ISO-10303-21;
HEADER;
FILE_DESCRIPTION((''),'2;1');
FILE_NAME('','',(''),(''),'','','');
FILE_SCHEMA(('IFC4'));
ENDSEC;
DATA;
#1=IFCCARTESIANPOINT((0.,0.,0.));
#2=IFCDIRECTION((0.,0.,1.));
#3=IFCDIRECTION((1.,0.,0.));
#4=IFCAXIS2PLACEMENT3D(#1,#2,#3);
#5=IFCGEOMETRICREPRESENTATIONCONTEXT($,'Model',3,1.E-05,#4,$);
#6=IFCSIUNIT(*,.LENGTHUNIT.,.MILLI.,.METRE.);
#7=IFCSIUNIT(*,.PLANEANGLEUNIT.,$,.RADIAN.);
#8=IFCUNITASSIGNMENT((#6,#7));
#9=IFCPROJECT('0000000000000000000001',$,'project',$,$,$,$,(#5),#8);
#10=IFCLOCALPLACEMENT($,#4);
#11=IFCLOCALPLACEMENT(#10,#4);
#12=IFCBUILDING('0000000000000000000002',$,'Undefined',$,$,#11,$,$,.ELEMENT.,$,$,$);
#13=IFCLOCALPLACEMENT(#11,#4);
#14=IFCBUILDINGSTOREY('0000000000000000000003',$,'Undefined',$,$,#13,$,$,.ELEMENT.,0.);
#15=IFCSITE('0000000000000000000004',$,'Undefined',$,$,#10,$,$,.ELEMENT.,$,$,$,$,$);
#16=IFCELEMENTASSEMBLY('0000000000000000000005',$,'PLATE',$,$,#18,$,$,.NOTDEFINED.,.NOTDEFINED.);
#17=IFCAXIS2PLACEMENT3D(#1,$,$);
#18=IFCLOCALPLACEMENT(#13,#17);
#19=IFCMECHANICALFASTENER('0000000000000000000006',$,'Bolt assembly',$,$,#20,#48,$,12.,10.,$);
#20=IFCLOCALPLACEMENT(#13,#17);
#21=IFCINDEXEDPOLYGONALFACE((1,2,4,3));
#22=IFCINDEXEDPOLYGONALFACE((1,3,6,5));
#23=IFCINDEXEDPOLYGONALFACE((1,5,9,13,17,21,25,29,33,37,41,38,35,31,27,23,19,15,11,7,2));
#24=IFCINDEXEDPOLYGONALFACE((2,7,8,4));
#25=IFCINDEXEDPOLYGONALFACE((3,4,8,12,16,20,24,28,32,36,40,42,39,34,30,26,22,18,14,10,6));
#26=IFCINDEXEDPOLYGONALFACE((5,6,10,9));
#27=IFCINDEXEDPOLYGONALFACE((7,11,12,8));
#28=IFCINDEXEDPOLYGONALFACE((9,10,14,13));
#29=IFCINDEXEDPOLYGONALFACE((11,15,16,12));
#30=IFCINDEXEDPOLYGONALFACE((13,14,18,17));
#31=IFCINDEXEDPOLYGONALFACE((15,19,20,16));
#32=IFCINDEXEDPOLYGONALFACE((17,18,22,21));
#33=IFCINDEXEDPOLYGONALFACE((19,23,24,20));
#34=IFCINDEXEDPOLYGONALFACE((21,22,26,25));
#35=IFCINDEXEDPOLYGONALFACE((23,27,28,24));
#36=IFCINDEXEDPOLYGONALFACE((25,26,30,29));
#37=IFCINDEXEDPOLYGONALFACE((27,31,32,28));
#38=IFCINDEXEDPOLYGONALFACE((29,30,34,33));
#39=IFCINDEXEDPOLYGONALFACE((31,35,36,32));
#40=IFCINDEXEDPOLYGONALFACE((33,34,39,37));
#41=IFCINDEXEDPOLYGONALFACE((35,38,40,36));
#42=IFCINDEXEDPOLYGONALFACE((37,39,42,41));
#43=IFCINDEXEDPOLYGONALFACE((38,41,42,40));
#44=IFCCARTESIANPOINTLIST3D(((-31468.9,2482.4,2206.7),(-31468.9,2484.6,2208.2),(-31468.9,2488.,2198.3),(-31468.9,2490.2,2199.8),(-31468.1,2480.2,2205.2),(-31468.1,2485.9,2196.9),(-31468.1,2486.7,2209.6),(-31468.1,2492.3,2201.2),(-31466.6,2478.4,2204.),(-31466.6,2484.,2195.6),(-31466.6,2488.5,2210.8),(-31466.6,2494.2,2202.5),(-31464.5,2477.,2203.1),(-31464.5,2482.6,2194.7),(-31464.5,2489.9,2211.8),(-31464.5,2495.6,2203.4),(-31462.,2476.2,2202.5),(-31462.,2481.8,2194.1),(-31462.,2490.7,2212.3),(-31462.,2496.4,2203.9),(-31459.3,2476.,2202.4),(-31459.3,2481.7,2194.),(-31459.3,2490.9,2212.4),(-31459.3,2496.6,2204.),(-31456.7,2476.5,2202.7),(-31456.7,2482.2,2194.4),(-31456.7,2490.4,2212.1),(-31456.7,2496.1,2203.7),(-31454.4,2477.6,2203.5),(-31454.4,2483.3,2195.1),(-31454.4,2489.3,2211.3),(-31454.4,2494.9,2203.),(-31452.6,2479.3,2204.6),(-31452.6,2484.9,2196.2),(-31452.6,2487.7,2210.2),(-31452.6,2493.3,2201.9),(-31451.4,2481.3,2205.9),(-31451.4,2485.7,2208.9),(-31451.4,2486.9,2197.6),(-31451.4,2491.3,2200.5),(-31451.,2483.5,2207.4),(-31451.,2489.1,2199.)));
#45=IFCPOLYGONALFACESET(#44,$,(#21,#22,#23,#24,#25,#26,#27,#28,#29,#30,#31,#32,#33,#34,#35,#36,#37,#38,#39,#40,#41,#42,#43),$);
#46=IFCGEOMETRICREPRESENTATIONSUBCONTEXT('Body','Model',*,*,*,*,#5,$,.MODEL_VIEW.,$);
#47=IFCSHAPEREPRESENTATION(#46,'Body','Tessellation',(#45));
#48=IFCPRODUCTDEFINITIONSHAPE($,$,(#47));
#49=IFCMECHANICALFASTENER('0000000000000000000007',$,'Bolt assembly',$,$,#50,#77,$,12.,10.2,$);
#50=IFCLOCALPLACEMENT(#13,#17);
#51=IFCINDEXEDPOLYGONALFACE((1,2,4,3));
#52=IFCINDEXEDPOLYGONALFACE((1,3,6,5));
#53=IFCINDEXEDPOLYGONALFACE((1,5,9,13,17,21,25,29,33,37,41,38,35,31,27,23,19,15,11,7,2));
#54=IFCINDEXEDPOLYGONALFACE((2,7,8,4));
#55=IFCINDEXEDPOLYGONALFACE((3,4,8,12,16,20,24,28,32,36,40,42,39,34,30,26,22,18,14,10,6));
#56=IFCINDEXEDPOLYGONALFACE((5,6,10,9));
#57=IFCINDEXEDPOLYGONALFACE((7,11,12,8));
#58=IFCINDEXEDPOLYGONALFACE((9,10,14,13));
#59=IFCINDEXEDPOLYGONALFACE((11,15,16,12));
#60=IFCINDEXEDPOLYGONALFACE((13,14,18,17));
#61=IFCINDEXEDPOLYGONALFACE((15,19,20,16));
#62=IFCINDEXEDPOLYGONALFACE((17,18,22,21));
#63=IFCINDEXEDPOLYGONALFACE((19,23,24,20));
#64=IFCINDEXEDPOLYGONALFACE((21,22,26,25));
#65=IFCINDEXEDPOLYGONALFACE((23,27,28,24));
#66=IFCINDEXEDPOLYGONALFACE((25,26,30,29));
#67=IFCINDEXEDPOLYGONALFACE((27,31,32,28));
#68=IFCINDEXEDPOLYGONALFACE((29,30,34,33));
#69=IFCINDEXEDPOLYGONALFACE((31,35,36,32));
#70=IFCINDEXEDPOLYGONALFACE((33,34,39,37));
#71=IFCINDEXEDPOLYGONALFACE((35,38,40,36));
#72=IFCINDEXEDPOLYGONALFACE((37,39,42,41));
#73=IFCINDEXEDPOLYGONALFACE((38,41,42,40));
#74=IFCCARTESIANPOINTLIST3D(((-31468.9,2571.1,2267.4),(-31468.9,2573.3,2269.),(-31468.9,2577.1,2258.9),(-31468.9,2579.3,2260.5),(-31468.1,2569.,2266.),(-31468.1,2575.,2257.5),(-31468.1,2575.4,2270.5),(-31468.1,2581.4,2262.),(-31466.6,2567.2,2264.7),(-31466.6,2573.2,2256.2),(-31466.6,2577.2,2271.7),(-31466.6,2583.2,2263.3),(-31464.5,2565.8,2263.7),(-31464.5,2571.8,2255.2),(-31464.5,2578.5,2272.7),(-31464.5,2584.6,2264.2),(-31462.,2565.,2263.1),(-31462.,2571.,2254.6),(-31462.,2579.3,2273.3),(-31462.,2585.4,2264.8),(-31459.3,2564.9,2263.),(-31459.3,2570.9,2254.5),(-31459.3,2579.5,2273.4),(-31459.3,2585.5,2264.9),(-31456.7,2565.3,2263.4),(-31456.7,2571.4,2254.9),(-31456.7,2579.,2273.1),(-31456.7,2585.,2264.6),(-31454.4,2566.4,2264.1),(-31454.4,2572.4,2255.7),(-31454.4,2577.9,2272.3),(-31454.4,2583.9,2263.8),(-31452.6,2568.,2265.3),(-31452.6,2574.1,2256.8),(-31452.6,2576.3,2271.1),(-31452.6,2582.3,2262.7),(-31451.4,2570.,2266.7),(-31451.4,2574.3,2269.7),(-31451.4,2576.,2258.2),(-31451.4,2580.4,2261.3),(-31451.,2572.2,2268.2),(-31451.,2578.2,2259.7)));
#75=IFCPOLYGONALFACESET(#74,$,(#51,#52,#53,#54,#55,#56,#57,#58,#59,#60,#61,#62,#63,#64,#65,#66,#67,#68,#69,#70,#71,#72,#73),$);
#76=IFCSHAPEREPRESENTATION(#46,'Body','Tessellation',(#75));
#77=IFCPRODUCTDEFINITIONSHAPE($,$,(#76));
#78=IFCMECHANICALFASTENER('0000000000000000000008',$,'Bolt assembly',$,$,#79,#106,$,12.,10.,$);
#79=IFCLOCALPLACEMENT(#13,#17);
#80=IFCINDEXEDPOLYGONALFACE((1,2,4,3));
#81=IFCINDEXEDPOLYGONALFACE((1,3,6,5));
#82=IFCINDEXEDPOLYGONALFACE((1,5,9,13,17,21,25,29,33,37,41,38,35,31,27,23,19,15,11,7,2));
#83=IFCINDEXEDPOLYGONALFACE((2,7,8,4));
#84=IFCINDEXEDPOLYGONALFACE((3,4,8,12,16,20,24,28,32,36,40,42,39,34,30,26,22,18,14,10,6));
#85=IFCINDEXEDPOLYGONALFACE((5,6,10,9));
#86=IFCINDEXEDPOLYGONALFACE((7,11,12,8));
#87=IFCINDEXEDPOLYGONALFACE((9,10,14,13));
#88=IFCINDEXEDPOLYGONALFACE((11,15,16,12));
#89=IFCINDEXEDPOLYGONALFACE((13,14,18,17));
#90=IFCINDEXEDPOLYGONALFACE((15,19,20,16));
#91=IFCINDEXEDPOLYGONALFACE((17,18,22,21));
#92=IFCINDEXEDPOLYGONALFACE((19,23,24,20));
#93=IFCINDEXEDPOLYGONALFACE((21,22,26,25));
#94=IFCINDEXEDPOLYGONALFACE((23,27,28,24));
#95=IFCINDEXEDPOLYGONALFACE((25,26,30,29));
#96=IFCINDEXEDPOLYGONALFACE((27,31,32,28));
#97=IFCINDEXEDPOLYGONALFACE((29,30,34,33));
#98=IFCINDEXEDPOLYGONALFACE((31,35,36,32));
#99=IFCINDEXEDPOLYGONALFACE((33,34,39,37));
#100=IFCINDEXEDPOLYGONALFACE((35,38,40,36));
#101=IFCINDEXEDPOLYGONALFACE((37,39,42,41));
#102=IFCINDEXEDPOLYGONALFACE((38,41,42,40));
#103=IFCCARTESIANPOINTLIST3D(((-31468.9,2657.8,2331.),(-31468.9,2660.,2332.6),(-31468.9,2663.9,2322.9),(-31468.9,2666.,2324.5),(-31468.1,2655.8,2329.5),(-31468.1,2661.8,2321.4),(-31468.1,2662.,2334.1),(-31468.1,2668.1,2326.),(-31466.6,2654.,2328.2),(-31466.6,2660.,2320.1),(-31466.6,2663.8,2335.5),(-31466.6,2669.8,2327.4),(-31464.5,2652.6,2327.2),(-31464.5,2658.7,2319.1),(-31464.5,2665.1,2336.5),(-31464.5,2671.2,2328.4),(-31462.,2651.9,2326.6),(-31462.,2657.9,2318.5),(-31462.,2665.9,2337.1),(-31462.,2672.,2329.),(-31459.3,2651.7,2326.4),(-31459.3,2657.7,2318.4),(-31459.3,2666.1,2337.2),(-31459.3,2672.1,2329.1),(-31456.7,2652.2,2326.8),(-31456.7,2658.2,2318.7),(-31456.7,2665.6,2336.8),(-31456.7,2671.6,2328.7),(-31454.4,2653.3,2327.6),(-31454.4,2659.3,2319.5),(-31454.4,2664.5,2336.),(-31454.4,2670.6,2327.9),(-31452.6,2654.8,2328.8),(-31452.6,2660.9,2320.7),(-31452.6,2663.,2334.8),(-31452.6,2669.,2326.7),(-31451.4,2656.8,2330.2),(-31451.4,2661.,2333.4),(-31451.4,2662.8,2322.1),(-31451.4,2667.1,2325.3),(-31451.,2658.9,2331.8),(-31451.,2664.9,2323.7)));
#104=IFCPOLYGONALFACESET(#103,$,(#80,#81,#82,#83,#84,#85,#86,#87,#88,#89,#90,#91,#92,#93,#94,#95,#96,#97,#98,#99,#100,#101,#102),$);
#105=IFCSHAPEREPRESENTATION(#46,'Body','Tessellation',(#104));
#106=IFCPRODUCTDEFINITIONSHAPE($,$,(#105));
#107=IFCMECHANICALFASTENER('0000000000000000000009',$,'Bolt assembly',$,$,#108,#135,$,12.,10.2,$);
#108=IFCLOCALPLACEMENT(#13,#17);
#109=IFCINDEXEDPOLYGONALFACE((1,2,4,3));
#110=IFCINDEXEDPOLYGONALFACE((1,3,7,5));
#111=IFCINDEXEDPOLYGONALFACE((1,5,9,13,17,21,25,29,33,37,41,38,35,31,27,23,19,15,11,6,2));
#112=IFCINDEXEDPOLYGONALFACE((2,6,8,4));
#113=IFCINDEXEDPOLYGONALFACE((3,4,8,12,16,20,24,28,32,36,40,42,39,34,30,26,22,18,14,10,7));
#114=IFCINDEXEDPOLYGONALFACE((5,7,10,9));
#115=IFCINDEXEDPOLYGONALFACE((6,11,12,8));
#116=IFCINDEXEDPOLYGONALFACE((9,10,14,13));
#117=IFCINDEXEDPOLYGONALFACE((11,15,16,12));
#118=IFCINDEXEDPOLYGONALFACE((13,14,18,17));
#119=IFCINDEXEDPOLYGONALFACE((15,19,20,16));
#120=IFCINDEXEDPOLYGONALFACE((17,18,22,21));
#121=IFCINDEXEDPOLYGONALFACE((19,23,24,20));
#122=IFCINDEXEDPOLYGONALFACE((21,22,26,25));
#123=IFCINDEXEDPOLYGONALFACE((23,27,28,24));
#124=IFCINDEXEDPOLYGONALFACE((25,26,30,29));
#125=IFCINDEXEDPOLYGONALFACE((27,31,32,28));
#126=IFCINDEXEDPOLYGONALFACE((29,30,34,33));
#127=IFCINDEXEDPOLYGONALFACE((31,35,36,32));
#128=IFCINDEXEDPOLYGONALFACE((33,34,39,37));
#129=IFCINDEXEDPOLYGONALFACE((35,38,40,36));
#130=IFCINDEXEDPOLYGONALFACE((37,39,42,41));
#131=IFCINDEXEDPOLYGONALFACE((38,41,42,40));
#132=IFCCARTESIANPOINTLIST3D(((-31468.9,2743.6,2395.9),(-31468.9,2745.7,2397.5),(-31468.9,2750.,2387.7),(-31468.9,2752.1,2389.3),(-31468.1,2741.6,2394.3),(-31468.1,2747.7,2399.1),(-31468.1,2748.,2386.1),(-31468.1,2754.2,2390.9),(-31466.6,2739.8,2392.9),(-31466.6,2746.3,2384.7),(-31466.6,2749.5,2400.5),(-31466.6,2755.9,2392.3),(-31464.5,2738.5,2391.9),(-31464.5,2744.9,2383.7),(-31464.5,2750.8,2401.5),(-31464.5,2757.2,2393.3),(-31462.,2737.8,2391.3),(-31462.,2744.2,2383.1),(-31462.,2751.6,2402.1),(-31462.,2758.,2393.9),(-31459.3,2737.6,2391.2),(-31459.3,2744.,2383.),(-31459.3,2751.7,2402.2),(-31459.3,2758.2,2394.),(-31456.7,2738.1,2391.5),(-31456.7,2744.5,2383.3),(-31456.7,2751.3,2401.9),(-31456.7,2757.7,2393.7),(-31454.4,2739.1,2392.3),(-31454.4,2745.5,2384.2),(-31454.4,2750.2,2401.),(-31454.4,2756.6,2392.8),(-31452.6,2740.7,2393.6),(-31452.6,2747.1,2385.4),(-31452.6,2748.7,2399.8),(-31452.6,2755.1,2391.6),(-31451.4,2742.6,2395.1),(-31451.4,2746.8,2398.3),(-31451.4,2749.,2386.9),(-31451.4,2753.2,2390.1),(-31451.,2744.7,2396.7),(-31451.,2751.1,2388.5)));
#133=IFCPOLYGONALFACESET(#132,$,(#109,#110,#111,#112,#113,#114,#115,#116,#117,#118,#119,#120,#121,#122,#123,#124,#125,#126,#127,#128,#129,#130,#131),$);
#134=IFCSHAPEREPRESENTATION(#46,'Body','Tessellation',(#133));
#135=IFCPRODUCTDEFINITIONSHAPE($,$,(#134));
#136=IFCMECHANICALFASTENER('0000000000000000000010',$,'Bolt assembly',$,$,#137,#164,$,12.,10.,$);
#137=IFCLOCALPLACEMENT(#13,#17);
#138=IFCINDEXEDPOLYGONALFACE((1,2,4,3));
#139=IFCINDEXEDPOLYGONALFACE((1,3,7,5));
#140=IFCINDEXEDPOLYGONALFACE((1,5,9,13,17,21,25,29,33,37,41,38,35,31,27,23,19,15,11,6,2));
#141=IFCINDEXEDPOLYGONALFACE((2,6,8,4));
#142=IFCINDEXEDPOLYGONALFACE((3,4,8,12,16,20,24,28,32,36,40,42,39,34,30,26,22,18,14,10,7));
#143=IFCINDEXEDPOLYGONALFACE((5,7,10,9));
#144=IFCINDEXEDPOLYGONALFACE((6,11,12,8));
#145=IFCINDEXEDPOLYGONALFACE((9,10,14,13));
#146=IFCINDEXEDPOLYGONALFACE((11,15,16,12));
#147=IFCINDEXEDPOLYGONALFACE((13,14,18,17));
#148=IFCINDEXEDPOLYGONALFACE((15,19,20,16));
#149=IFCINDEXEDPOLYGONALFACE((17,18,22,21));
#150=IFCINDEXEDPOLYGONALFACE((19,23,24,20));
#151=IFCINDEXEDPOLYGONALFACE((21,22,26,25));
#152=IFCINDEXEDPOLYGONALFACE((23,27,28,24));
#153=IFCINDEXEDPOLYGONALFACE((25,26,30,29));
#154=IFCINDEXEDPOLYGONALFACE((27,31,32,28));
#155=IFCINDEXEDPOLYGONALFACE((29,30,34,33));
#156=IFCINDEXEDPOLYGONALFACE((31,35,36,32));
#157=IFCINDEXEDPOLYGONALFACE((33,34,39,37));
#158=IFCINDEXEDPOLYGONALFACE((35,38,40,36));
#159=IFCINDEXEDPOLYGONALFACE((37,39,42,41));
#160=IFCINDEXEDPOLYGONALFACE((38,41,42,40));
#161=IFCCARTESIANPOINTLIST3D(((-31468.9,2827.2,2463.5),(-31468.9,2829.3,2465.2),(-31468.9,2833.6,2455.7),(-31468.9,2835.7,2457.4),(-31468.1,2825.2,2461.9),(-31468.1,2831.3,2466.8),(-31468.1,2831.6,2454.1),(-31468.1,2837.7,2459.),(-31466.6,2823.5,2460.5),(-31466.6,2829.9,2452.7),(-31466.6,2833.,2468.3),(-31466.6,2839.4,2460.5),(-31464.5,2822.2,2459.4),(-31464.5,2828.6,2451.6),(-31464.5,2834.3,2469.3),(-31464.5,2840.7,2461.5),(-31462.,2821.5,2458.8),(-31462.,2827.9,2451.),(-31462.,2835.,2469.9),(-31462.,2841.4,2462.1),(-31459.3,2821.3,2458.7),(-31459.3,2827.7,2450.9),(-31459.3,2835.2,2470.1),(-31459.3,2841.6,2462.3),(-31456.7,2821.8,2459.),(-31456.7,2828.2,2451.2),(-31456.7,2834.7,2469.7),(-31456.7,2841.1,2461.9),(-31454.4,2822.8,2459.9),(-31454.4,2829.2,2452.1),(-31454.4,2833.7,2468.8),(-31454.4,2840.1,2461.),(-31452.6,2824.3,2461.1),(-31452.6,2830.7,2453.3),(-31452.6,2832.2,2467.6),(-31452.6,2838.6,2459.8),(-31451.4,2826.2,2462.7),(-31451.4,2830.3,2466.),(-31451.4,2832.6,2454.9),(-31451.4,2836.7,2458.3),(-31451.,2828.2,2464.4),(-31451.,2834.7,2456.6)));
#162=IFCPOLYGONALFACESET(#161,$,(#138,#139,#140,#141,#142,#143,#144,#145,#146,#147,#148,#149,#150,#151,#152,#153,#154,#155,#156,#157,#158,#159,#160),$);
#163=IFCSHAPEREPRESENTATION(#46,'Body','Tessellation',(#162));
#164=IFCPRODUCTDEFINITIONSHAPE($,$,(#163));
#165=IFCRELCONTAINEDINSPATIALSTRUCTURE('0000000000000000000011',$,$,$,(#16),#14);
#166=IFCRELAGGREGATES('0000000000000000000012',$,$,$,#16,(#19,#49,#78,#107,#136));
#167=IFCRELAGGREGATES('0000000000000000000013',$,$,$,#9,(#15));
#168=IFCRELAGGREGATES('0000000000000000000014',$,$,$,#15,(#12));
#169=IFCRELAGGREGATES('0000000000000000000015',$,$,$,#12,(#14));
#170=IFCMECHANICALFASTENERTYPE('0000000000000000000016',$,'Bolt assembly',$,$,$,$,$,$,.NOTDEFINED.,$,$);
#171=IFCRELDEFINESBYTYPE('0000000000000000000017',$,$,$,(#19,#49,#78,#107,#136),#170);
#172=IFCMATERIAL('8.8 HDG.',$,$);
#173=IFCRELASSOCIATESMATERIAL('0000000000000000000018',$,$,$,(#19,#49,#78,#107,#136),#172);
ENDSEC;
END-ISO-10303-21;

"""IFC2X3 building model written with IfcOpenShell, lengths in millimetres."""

from ifc_helpers import new_model, si_unit, frame, origin_with_axes, origin_2d_with_axis, place, context, subcontext, project, spatial, circle, extrude, source, transform, mapped, material, type_object, element, aggregate, save


model = new_model("IFC2X3")

# Units and contexts
model_context = context("Model", 3, precision=1e-05, world=origin_with_axes())
body_context = subcontext(model_context, "Body", "Model", "MODEL_VIEW")
ifc_project = project(units=[si_unit("LENGTHUNIT", "METRE", prefix="MILLI"), si_unit("PLANEANGLEUNIT", "RADIAN")], contexts=[model_context])

# Site, building, storey
site_placement = place(None, origin_with_axes())
site = spatial("IfcSite", under=ifc_project, at=site_placement, Name="Undefined", CompositionType="ELEMENT")
building_placement = place(site_placement, origin_with_axes())
building = spatial("IfcBuilding", under=site, at=building_placement, Name="Undefined", CompositionType="ELEMENT")
storey_placement = place(building_placement, origin_with_axes())
storey = spatial("IfcBuildingStorey", under=building, at=storey_placement, Name="Undefined", CompositionType="ELEMENT", Elevation=0.0)

# Element assembly, mechanical fasteners
assembly_placement = place(storey_placement, origin_with_axes())
assembly = element("IfcElementAssembly", 1, at=assembly_placement, inside=storey, Name="PLATE", AssemblyPlace="NOTDEFINED", PredefinedType="NOTDEFINED")
ifc_material_1 = material(Name="8.8 HDG.")
mechanical_fastener_type = type_object("IfcMechanicalFastenerType", Name="Bolt assembly")
shared_shape_1 = source(origin_with_axes(), body_context, "Body", "SweptSolid", [
    extrude(circle(Radius=9.0, at=origin_2d_with_axis()), frame((0.0, 0.8, 0.0), z_axis=(0.0, 1.0, 0.0), x_axis=(1.0, 0.0, 0.0)), (0.0, 0.0, 1.0), 10.1),
])
mechanical_fastener_1_placement = place(assembly_placement, frame((-31460.0, 2489.6, 2198.4), z_axis=(0.000001, -0.829788, -0.558079), x_axis=(1.0, 0.000001, 0.0)))
mechanical_fastener_1 = element("IfcMechanicalFastener", 2, at=mechanical_fastener_1_placement, type_object=mechanical_fastener_type, material=ifc_material_1, Name="Bolt assembly", NominalDiameter=12.0, NominalLength=10.0, context=body_context, shape_type="MappedRepresentation", body=[
    mapped(shared_shape_1, transform((0.0, 0.0, 0.0))),
])
shared_shape_2 = source(origin_with_axes(), body_context, "Body", "SweptSolid", [
    extrude(circle(Radius=9.0, at=origin_2d_with_axis()), frame((0.0, 0.2, 0.0), z_axis=(0.0, 1.0, 0.0), x_axis=(1.0, 0.0, 0.0)), (0.0, 0.0, 1.0), 10.4),
])
mechanical_fastener_2_placement = place(assembly_placement, frame((-31460.0, 2578.3, 2259.6), z_axis=(0.000001, -0.81606, -0.577967), x_axis=(1.0, 0.000001, 0.0)))
mechanical_fastener_2 = element("IfcMechanicalFastener", 3, at=mechanical_fastener_2_placement, type_object=mechanical_fastener_type, material=ifc_material_1, Name="Bolt assembly", NominalDiameter=12.0, NominalLength=10.2, context=body_context, shape_type="MappedRepresentation", body=[
    mapped(shared_shape_2, transform((0.0, 0.0, 0.0))),
])
shared_shape_3 = source(origin_with_axes(), body_context, "Body", "SweptSolid", [
    extrude(circle(Radius=9.0, at=origin_2d_with_axis()), frame((0.0, 0.9, 0.0), z_axis=(0.0, 1.0, 0.0), x_axis=(1.0, 0.0, 0.0)), (0.0, 0.0, 1.0), 10.1),
])
mechanical_fastener_3_placement = place(assembly_placement, frame((-31460.0, 2665.5, 2323.0), z_axis=(0.000001, -0.801856, -0.597518), x_axis=(1.0, 0.000001, 0.0)))
mechanical_fastener_3 = element("IfcMechanicalFastener", 4, at=mechanical_fastener_3_placement, type_object=mechanical_fastener_type, material=ifc_material_1, Name="Bolt assembly", NominalDiameter=12.0, NominalLength=10.0, context=body_context, shape_type="MappedRepresentation", body=[
    mapped(shared_shape_3, transform((0.0, 0.0, 0.0))),
])
shared_shape_4 = source(origin_with_axes(), body_context, "Body", "SweptSolid", [
    extrude(circle(Radius=9.0, at=origin_2d_with_axis()), frame((0.0, 0.1, 0.0), z_axis=(0.0, 1.0, 0.0), x_axis=(1.0, 0.0, 0.0)), (0.0, 0.0, 1.0), 10.4),
])
mechanical_fastener_4_placement = place(assembly_placement, frame((-31460.0, 2751.1, 2388.4), z_axis=(0.000001, -0.787183, -0.616719), x_axis=(1.0, 0.000001, 0.000001)))
mechanical_fastener_4 = element("IfcMechanicalFastener", 5, at=mechanical_fastener_4_placement, type_object=mechanical_fastener_type, material=ifc_material_1, Name="Bolt assembly", NominalDiameter=12.0, NominalLength=10.2, context=body_context, shape_type="MappedRepresentation", body=[
    mapped(shared_shape_4, transform((0.0, 0.0, 0.0))),
])
shared_shape_5 = source(origin_with_axes(), body_context, "Body", "SweptSolid", [
    extrude(circle(Radius=9.0, at=origin_2d_with_axis()), frame((0.0, 0.8, 0.0), z_axis=(0.0, 1.0, 0.0), x_axis=(1.0, 0.0, 0.0)), (0.0, 0.0, 1.0), 10.1),
])
mechanical_fastener_5_placement = place(assembly_placement, frame((-31460.0, 2835.2, 2455.9), z_axis=(0.000001, -0.772051, -0.63556), x_axis=(1.0, 0.000001, 0.000001)))
mechanical_fastener_5 = element("IfcMechanicalFastener", 6, at=mechanical_fastener_5_placement, type_object=mechanical_fastener_type, material=ifc_material_1, Name="Bolt assembly", NominalDiameter=12.0, NominalLength=10.0, context=body_context, shape_type="MappedRepresentation", body=[
    mapped(shared_shape_5, transform((0.0, 0.0, 0.0))),
])
aggregate(assembly, [mechanical_fastener_1, mechanical_fastener_2, mechanical_fastener_3, mechanical_fastener_4, mechanical_fastener_5])

save(model, "model.ifc")
